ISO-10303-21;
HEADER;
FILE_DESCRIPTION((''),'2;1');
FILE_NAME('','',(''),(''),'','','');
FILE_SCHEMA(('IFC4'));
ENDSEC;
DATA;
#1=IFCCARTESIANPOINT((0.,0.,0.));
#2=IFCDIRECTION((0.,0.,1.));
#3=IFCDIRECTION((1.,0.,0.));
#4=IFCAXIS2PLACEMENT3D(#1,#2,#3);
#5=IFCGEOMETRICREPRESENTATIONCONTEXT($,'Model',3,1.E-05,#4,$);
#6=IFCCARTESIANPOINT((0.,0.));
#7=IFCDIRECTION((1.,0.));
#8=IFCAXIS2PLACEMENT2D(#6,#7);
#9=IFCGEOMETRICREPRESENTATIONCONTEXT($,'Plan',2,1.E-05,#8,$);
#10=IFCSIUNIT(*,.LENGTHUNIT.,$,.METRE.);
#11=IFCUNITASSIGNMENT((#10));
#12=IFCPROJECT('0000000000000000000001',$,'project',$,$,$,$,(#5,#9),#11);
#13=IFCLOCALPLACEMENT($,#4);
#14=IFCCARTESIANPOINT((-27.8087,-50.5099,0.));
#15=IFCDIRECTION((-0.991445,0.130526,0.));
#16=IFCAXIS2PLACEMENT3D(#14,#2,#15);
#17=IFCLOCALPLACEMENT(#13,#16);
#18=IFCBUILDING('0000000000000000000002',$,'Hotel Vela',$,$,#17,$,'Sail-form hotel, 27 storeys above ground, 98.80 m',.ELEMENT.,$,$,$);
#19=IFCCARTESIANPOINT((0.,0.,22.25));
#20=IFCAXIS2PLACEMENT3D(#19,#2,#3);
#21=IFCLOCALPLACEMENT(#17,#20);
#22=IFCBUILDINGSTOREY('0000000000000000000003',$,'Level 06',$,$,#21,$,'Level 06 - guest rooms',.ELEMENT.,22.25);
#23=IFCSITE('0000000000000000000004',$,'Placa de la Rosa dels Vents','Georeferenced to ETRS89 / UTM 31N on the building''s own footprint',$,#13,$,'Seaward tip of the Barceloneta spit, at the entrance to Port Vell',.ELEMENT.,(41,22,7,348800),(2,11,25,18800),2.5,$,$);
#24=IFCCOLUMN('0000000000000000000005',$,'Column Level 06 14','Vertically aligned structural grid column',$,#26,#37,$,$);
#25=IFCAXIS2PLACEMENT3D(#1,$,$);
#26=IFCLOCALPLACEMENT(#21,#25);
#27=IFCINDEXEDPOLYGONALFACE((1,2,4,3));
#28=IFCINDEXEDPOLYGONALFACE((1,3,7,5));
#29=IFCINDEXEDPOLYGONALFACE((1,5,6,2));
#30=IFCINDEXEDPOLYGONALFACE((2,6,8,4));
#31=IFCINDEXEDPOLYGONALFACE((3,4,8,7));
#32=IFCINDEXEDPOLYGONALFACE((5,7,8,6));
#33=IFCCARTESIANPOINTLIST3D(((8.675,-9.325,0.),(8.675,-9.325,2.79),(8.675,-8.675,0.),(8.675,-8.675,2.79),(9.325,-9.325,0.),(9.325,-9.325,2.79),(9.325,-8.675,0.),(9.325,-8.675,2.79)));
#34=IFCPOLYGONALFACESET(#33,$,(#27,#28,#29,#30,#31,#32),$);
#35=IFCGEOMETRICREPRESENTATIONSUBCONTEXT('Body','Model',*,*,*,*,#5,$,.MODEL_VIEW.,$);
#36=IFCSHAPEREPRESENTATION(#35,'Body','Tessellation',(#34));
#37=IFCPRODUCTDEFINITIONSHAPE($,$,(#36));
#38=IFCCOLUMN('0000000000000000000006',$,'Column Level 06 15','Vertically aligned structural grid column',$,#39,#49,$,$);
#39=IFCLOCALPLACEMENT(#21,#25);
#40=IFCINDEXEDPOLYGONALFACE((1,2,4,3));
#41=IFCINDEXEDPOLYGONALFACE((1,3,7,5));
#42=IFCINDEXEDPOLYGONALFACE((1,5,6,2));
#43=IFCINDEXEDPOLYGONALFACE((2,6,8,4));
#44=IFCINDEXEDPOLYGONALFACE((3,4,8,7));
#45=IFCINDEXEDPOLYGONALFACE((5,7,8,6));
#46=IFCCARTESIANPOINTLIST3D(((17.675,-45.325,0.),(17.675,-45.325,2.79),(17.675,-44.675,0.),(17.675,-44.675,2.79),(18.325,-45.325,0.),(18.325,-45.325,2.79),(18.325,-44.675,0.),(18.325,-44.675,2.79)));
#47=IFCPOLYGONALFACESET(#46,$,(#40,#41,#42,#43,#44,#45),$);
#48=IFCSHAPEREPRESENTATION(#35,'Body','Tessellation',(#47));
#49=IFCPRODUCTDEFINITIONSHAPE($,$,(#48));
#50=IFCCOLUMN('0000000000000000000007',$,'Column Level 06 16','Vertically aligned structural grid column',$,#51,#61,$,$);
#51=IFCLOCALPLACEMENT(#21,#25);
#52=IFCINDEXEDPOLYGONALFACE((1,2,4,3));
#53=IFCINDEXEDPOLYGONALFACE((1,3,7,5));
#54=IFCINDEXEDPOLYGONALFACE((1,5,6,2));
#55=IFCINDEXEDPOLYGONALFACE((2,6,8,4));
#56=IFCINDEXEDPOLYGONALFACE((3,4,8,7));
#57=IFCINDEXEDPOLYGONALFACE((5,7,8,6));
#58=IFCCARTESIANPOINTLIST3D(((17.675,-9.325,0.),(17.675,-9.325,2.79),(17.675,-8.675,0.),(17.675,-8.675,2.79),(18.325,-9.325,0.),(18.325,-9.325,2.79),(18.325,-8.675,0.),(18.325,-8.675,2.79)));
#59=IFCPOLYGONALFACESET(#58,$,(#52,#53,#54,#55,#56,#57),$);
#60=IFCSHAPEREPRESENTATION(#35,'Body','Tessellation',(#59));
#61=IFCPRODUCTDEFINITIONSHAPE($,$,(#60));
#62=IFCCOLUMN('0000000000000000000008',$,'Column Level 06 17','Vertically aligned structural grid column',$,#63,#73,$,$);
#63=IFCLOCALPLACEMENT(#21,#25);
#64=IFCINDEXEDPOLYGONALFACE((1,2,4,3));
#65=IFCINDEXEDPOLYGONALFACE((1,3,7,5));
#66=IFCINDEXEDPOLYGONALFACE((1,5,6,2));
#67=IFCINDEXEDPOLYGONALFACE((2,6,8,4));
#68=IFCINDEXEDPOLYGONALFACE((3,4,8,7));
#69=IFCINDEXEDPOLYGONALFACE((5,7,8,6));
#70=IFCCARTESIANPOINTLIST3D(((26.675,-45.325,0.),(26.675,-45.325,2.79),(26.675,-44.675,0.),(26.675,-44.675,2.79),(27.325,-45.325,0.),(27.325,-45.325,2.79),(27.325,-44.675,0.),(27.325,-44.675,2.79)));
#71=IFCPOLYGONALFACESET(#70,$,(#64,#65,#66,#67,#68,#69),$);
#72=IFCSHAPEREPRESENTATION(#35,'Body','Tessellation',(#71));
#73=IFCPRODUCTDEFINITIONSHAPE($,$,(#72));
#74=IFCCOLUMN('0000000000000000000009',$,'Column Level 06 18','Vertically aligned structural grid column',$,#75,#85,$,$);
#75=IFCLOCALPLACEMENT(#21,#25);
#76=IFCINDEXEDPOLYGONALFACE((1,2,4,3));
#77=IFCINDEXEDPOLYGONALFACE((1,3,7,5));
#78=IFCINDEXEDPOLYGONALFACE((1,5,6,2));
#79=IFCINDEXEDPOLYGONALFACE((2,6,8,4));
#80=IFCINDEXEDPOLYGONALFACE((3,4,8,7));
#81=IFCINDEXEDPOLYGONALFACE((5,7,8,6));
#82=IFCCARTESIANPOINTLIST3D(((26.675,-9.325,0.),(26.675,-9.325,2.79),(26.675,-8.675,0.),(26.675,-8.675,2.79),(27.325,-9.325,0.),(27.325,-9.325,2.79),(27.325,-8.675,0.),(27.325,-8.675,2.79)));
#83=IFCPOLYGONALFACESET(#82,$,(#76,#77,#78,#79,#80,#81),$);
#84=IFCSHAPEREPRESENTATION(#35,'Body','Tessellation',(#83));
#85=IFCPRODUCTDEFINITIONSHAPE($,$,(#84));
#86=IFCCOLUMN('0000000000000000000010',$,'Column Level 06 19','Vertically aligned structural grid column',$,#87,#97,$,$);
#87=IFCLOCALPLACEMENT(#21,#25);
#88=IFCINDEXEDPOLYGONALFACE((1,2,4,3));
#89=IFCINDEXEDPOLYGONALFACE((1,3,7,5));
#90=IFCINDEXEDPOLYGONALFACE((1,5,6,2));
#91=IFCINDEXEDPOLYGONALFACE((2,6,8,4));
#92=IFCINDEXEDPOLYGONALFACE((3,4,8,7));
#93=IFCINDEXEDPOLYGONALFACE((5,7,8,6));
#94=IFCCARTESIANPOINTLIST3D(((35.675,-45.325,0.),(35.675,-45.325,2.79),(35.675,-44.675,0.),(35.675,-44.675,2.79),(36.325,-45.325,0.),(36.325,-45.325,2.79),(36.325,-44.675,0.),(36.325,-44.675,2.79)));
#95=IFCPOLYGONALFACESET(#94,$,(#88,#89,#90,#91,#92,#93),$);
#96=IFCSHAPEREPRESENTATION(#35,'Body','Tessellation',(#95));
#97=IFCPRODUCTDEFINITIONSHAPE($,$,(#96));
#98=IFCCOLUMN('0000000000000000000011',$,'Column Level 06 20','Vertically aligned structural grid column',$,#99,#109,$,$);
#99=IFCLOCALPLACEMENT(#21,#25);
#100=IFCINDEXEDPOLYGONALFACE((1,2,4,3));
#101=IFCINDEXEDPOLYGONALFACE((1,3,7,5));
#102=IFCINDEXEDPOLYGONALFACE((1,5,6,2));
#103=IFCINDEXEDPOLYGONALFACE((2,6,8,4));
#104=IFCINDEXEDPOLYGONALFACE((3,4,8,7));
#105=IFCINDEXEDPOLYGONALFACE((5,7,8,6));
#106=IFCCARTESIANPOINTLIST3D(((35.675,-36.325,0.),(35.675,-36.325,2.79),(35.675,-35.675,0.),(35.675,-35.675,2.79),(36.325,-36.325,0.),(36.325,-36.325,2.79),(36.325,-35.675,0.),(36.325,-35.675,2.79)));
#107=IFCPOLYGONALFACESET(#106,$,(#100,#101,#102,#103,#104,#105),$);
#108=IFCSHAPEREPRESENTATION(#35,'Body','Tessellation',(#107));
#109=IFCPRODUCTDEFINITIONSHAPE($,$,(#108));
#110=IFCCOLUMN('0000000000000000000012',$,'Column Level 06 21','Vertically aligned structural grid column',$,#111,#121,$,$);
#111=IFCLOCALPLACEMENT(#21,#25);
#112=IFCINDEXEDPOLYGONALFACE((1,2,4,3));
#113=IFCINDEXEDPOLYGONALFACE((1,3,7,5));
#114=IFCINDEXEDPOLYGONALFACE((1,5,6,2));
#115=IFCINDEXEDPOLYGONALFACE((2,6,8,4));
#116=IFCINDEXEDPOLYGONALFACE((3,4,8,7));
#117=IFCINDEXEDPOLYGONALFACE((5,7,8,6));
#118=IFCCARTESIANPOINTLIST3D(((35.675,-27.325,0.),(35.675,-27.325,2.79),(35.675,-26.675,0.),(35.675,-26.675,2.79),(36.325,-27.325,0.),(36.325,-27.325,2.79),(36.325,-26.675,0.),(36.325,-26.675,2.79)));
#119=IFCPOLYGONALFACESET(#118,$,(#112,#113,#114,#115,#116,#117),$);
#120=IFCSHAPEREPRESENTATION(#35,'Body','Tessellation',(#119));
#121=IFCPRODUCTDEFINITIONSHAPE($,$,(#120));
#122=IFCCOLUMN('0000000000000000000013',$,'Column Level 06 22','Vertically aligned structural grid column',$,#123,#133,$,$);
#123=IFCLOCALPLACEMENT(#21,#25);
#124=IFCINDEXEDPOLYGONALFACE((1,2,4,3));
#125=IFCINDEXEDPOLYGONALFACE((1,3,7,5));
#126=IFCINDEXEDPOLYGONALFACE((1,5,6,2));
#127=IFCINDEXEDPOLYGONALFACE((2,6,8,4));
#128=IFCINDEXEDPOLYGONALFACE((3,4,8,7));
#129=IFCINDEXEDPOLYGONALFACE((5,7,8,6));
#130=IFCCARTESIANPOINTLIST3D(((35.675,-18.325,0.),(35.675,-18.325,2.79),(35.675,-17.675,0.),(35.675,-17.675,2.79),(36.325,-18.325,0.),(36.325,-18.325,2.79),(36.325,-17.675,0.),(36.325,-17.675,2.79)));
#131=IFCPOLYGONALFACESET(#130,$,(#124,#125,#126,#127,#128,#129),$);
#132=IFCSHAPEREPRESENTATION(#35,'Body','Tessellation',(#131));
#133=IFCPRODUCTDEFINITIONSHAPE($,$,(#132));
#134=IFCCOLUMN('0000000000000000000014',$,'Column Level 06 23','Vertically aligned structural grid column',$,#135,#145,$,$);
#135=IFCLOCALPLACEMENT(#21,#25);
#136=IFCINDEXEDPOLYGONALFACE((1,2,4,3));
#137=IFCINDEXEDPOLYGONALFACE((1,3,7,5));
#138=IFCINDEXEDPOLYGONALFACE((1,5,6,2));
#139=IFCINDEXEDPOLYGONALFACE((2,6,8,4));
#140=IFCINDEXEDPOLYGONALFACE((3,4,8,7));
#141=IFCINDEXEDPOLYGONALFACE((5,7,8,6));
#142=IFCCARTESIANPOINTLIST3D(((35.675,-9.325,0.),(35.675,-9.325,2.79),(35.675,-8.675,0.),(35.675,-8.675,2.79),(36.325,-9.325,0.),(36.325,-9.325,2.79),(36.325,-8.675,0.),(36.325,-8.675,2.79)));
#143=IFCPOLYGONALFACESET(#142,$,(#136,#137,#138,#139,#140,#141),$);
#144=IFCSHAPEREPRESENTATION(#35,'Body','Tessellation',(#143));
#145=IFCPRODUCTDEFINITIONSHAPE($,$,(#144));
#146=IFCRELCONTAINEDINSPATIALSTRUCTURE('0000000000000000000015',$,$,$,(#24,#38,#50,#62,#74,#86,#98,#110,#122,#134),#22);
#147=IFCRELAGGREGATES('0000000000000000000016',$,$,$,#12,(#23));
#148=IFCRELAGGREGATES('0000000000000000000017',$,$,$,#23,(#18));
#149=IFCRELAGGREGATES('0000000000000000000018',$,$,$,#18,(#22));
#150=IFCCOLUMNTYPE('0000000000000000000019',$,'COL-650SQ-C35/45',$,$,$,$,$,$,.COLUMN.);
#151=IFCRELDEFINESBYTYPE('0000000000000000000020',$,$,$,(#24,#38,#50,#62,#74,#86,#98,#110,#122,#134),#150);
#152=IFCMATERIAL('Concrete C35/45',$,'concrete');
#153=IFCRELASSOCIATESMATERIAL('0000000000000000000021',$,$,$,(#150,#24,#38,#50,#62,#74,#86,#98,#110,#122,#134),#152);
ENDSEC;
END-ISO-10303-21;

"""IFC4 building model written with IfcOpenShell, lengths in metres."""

from ifc_helpers import new_model, si_unit, frame, origin_with_axes, origin_2d_with_axis, place, context, subcontext, project, spatial, line, indexed_curve, rectangle, outline, extrude, material, material_profile, profile_set, profile_usage, type_object, element, save


model = new_model("IFC4")

# Units and contexts
model_context = context("Model", 3, precision=1e-05, world=origin_with_axes())
plan_context = context("Plan", 2, precision=1e-05, world=origin_2d_with_axis())
body_context = subcontext(model_context, "Body", "Model", "MODEL_VIEW")
ifc_project = project(units=[si_unit("LENGTHUNIT", "METRE")], contexts=[model_context, plan_context])

# Site, building, storey
site_placement = place(None, origin_with_axes())
site = spatial("IfcSite", under=ifc_project, at=site_placement, Name="Placa de la Rosa dels Vents", Description="Georeferenced to ETRS89 / UTM 31N on the building's own footprint", LongName="Seaward tip of the Barceloneta spit, at the entrance to Port Vell", CompositionType="ELEMENT", RefLatitude=(41, 22, 7, 348800), RefLongitude=(2, 11, 25, 18800), RefElevation=2.5)
building_placement = place(site_placement, frame((-27.8087, -50.5099, 0.0), z_axis=(0.0, 0.0, 1.0), x_axis=(-0.991445, 0.130526, 0.0)))
building = spatial("IfcBuilding", under=site, at=building_placement, Name="Hotel Vela", LongName="Sail-form hotel, 27 storeys above ground, 98.80 m", CompositionType="ELEMENT")
storey_placement = place(building_placement, frame((0.0, 0.0, 22.25), z_axis=(0.0, 0.0, 1.0), x_axis=(1.0, 0.0, 0.0)))
storey = spatial("IfcBuildingStorey", under=building, at=storey_placement, Name="Level 06", LongName="Level 06 - guest rooms", CompositionType="ELEMENT", Elevation=22.25)

# Columns
ifc_material = material(Name="Concrete C35/45", Category="concrete")
ifc_material_profile = material_profile(ifc_material, rectangle(XDim=0.65, YDim=0.65))
ifc_profile_set = profile_set([ifc_material_profile], Name="COL-650SQ-C35/45")
column_type = type_object("IfcColumnType", Name="COL-650SQ-C35/45", PredefinedType="COLUMN", material=ifc_profile_set)
ifc_profile_usage_1 = profile_usage(ifc_profile_set)
column_1_placement = place(storey_placement, frame((8.675, -9.325, 0.0), z_axis=(0.0, 0.0, 1.0), x_axis=(1.0, 0.0, 0.0)))
element("IfcColumn", 1, at=column_1_placement, inside=storey, type_object=column_type, material=ifc_profile_usage_1, Name="Column Level 06 14", Description="Vertically aligned structural grid column", context=body_context, shape_type="SweptSolid", body=[
    extrude(outline(indexed_curve([(0.0, 0.0), (0.65, 0.0), (0.65, 0.65), (0.0, 0.65)], segments=[line(1, 2, 3, 4, 1)])), origin_with_axes(), (0.0, 0.0, 1.0), 2.79),
])
ifc_profile_usage_2 = profile_usage(ifc_profile_set)
column_2_placement = place(storey_placement, frame((17.675, -45.325, 0.0), z_axis=(0.0, 0.0, 1.0), x_axis=(1.0, 0.0, 0.0)))
element("IfcColumn", 2, at=column_2_placement, inside=storey, type_object=column_type, material=ifc_profile_usage_2, Name="Column Level 06 15", Description="Vertically aligned structural grid column", context=body_context, shape_type="SweptSolid", body=[
    extrude(outline(indexed_curve([(0.0, 0.0), (0.65, 0.0), (0.65, 0.65), (0.0, 0.65)], segments=[line(1, 2, 3, 4, 1)])), origin_with_axes(), (0.0, 0.0, 1.0), 2.79),
])
ifc_profile_usage_3 = profile_usage(ifc_profile_set)
column_3_placement = place(storey_placement, frame((17.675, -9.325, 0.0), z_axis=(0.0, 0.0, 1.0), x_axis=(1.0, 0.0, 0.0)))
element("IfcColumn", 3, at=column_3_placement, inside=storey, type_object=column_type, material=ifc_profile_usage_3, Name="Column Level 06 16", Description="Vertically aligned structural grid column", context=body_context, shape_type="SweptSolid", body=[
    extrude(outline(indexed_curve([(0.0, 0.0), (0.65, 0.0), (0.65, 0.65), (0.0, 0.65)], segments=[line(1, 2, 3, 4, 1)])), origin_with_axes(), (0.0, 0.0, 1.0), 2.79),
])
ifc_profile_usage_4 = profile_usage(ifc_profile_set)
column_4_placement = place(storey_placement, frame((26.675, -45.325, 0.0), z_axis=(0.0, 0.0, 1.0), x_axis=(1.0, 0.0, 0.0)))
element("IfcColumn", 4, at=column_4_placement, inside=storey, type_object=column_type, material=ifc_profile_usage_4, Name="Column Level 06 17", Description="Vertically aligned structural grid column", context=body_context, shape_type="SweptSolid", body=[
    extrude(outline(indexed_curve([(0.0, 0.0), (0.65, 0.0), (0.65, 0.65), (0.0, 0.65)], segments=[line(1, 2, 3, 4, 1)])), origin_with_axes(), (0.0, 0.0, 1.0), 2.79),
])
ifc_profile_usage_5 = profile_usage(ifc_profile_set)
column_5_placement = place(storey_placement, frame((26.675, -9.325, 0.0), z_axis=(0.0, 0.0, 1.0), x_axis=(1.0, 0.0, 0.0)))
element("IfcColumn", 5, at=column_5_placement, inside=storey, type_object=column_type, material=ifc_profile_usage_5, Name="Column Level 06 18", Description="Vertically aligned structural grid column", context=body_context, shape_type="SweptSolid", body=[
    extrude(outline(indexed_curve([(0.0, 0.0), (0.65, 0.0), (0.65, 0.65), (0.0, 0.65)], segments=[line(1, 2, 3, 4, 1)])), origin_with_axes(), (0.0, 0.0, 1.0), 2.79),
])
ifc_profile_usage_6 = profile_usage(ifc_profile_set)
column_6_placement = place(storey_placement, frame((35.675, -45.325, 0.0), z_axis=(0.0, 0.0, 1.0), x_axis=(1.0, 0.0, 0.0)))
element("IfcColumn", 6, at=column_6_placement, inside=storey, type_object=column_type, material=ifc_profile_usage_6, Name="Column Level 06 19", Description="Vertically aligned structural grid column", context=body_context, shape_type="SweptSolid", body=[
    extrude(outline(indexed_curve([(0.0, 0.0), (0.65, 0.0), (0.65, 0.65), (0.0, 0.65)], segments=[line(1, 2, 3, 4, 1)])), origin_with_axes(), (0.0, 0.0, 1.0), 2.79),
])
ifc_profile_usage_7 = profile_usage(ifc_profile_set)
column_7_placement = place(storey_placement, frame((35.675, -36.325, 0.0), z_axis=(0.0, 0.0, 1.0), x_axis=(1.0, 0.0, 0.0)))
element("IfcColumn", 7, at=column_7_placement, inside=storey, type_object=column_type, material=ifc_profile_usage_7, Name="Column Level 06 20", Description="Vertically aligned structural grid column", context=body_context, shape_type="SweptSolid", body=[
    extrude(outline(indexed_curve([(0.0, 0.0), (0.65, 0.0), (0.65, 0.65), (0.0, 0.65)], segments=[line(1, 2, 3, 4, 1)])), origin_with_axes(), (0.0, 0.0, 1.0), 2.79),
])
ifc_profile_usage_8 = profile_usage(ifc_profile_set)
column_8_placement = place(storey_placement, frame((35.675, -27.325, 0.0), z_axis=(0.0, 0.0, 1.0), x_axis=(1.0, 0.0, 0.0)))
element("IfcColumn", 8, at=column_8_placement, inside=storey, type_object=column_type, material=ifc_profile_usage_8, Name="Column Level 06 21", Description="Vertically aligned structural grid column", context=body_context, shape_type="SweptSolid", body=[
    extrude(outline(indexed_curve([(0.0, 0.0), (0.65, 0.0), (0.65, 0.65), (0.0, 0.65)], segments=[line(1, 2, 3, 4, 1)])), origin_with_axes(), (0.0, 0.0, 1.0), 2.79),
])
ifc_profile_usage_9 = profile_usage(ifc_profile_set)
column_9_placement = place(storey_placement, frame((35.675, -18.325, 0.0), z_axis=(0.0, 0.0, 1.0), x_axis=(1.0, 0.0, 0.0)))
element("IfcColumn", 9, at=column_9_placement, inside=storey, type_object=column_type, material=ifc_profile_usage_9, Name="Column Level 06 22", Description="Vertically aligned structural grid column", context=body_context, shape_type="SweptSolid", body=[
    extrude(outline(indexed_curve([(0.0, 0.0), (0.65, 0.0), (0.65, 0.65), (0.0, 0.65)], segments=[line(1, 2, 3, 4, 1)])), origin_with_axes(), (0.0, 0.0, 1.0), 2.79),
])
ifc_profile_usage_10 = profile_usage(ifc_profile_set)
column_10_placement = place(storey_placement, frame((35.675, -9.325, 0.0), z_axis=(0.0, 0.0, 1.0), x_axis=(1.0, 0.0, 0.0)))
element("IfcColumn", 10, at=column_10_placement, inside=storey, type_object=column_type, material=ifc_profile_usage_10, Name="Column Level 06 23", Description="Vertically aligned structural grid column", context=body_context, shape_type="SweptSolid", body=[
    extrude(outline(indexed_curve([(0.0, 0.0), (0.65, 0.0), (0.65, 0.65), (0.0, 0.65)], segments=[line(1, 2, 3, 4, 1)])), origin_with_axes(), (0.0, 0.0, 1.0), 2.79),
])

save(model, "model.ifc")
